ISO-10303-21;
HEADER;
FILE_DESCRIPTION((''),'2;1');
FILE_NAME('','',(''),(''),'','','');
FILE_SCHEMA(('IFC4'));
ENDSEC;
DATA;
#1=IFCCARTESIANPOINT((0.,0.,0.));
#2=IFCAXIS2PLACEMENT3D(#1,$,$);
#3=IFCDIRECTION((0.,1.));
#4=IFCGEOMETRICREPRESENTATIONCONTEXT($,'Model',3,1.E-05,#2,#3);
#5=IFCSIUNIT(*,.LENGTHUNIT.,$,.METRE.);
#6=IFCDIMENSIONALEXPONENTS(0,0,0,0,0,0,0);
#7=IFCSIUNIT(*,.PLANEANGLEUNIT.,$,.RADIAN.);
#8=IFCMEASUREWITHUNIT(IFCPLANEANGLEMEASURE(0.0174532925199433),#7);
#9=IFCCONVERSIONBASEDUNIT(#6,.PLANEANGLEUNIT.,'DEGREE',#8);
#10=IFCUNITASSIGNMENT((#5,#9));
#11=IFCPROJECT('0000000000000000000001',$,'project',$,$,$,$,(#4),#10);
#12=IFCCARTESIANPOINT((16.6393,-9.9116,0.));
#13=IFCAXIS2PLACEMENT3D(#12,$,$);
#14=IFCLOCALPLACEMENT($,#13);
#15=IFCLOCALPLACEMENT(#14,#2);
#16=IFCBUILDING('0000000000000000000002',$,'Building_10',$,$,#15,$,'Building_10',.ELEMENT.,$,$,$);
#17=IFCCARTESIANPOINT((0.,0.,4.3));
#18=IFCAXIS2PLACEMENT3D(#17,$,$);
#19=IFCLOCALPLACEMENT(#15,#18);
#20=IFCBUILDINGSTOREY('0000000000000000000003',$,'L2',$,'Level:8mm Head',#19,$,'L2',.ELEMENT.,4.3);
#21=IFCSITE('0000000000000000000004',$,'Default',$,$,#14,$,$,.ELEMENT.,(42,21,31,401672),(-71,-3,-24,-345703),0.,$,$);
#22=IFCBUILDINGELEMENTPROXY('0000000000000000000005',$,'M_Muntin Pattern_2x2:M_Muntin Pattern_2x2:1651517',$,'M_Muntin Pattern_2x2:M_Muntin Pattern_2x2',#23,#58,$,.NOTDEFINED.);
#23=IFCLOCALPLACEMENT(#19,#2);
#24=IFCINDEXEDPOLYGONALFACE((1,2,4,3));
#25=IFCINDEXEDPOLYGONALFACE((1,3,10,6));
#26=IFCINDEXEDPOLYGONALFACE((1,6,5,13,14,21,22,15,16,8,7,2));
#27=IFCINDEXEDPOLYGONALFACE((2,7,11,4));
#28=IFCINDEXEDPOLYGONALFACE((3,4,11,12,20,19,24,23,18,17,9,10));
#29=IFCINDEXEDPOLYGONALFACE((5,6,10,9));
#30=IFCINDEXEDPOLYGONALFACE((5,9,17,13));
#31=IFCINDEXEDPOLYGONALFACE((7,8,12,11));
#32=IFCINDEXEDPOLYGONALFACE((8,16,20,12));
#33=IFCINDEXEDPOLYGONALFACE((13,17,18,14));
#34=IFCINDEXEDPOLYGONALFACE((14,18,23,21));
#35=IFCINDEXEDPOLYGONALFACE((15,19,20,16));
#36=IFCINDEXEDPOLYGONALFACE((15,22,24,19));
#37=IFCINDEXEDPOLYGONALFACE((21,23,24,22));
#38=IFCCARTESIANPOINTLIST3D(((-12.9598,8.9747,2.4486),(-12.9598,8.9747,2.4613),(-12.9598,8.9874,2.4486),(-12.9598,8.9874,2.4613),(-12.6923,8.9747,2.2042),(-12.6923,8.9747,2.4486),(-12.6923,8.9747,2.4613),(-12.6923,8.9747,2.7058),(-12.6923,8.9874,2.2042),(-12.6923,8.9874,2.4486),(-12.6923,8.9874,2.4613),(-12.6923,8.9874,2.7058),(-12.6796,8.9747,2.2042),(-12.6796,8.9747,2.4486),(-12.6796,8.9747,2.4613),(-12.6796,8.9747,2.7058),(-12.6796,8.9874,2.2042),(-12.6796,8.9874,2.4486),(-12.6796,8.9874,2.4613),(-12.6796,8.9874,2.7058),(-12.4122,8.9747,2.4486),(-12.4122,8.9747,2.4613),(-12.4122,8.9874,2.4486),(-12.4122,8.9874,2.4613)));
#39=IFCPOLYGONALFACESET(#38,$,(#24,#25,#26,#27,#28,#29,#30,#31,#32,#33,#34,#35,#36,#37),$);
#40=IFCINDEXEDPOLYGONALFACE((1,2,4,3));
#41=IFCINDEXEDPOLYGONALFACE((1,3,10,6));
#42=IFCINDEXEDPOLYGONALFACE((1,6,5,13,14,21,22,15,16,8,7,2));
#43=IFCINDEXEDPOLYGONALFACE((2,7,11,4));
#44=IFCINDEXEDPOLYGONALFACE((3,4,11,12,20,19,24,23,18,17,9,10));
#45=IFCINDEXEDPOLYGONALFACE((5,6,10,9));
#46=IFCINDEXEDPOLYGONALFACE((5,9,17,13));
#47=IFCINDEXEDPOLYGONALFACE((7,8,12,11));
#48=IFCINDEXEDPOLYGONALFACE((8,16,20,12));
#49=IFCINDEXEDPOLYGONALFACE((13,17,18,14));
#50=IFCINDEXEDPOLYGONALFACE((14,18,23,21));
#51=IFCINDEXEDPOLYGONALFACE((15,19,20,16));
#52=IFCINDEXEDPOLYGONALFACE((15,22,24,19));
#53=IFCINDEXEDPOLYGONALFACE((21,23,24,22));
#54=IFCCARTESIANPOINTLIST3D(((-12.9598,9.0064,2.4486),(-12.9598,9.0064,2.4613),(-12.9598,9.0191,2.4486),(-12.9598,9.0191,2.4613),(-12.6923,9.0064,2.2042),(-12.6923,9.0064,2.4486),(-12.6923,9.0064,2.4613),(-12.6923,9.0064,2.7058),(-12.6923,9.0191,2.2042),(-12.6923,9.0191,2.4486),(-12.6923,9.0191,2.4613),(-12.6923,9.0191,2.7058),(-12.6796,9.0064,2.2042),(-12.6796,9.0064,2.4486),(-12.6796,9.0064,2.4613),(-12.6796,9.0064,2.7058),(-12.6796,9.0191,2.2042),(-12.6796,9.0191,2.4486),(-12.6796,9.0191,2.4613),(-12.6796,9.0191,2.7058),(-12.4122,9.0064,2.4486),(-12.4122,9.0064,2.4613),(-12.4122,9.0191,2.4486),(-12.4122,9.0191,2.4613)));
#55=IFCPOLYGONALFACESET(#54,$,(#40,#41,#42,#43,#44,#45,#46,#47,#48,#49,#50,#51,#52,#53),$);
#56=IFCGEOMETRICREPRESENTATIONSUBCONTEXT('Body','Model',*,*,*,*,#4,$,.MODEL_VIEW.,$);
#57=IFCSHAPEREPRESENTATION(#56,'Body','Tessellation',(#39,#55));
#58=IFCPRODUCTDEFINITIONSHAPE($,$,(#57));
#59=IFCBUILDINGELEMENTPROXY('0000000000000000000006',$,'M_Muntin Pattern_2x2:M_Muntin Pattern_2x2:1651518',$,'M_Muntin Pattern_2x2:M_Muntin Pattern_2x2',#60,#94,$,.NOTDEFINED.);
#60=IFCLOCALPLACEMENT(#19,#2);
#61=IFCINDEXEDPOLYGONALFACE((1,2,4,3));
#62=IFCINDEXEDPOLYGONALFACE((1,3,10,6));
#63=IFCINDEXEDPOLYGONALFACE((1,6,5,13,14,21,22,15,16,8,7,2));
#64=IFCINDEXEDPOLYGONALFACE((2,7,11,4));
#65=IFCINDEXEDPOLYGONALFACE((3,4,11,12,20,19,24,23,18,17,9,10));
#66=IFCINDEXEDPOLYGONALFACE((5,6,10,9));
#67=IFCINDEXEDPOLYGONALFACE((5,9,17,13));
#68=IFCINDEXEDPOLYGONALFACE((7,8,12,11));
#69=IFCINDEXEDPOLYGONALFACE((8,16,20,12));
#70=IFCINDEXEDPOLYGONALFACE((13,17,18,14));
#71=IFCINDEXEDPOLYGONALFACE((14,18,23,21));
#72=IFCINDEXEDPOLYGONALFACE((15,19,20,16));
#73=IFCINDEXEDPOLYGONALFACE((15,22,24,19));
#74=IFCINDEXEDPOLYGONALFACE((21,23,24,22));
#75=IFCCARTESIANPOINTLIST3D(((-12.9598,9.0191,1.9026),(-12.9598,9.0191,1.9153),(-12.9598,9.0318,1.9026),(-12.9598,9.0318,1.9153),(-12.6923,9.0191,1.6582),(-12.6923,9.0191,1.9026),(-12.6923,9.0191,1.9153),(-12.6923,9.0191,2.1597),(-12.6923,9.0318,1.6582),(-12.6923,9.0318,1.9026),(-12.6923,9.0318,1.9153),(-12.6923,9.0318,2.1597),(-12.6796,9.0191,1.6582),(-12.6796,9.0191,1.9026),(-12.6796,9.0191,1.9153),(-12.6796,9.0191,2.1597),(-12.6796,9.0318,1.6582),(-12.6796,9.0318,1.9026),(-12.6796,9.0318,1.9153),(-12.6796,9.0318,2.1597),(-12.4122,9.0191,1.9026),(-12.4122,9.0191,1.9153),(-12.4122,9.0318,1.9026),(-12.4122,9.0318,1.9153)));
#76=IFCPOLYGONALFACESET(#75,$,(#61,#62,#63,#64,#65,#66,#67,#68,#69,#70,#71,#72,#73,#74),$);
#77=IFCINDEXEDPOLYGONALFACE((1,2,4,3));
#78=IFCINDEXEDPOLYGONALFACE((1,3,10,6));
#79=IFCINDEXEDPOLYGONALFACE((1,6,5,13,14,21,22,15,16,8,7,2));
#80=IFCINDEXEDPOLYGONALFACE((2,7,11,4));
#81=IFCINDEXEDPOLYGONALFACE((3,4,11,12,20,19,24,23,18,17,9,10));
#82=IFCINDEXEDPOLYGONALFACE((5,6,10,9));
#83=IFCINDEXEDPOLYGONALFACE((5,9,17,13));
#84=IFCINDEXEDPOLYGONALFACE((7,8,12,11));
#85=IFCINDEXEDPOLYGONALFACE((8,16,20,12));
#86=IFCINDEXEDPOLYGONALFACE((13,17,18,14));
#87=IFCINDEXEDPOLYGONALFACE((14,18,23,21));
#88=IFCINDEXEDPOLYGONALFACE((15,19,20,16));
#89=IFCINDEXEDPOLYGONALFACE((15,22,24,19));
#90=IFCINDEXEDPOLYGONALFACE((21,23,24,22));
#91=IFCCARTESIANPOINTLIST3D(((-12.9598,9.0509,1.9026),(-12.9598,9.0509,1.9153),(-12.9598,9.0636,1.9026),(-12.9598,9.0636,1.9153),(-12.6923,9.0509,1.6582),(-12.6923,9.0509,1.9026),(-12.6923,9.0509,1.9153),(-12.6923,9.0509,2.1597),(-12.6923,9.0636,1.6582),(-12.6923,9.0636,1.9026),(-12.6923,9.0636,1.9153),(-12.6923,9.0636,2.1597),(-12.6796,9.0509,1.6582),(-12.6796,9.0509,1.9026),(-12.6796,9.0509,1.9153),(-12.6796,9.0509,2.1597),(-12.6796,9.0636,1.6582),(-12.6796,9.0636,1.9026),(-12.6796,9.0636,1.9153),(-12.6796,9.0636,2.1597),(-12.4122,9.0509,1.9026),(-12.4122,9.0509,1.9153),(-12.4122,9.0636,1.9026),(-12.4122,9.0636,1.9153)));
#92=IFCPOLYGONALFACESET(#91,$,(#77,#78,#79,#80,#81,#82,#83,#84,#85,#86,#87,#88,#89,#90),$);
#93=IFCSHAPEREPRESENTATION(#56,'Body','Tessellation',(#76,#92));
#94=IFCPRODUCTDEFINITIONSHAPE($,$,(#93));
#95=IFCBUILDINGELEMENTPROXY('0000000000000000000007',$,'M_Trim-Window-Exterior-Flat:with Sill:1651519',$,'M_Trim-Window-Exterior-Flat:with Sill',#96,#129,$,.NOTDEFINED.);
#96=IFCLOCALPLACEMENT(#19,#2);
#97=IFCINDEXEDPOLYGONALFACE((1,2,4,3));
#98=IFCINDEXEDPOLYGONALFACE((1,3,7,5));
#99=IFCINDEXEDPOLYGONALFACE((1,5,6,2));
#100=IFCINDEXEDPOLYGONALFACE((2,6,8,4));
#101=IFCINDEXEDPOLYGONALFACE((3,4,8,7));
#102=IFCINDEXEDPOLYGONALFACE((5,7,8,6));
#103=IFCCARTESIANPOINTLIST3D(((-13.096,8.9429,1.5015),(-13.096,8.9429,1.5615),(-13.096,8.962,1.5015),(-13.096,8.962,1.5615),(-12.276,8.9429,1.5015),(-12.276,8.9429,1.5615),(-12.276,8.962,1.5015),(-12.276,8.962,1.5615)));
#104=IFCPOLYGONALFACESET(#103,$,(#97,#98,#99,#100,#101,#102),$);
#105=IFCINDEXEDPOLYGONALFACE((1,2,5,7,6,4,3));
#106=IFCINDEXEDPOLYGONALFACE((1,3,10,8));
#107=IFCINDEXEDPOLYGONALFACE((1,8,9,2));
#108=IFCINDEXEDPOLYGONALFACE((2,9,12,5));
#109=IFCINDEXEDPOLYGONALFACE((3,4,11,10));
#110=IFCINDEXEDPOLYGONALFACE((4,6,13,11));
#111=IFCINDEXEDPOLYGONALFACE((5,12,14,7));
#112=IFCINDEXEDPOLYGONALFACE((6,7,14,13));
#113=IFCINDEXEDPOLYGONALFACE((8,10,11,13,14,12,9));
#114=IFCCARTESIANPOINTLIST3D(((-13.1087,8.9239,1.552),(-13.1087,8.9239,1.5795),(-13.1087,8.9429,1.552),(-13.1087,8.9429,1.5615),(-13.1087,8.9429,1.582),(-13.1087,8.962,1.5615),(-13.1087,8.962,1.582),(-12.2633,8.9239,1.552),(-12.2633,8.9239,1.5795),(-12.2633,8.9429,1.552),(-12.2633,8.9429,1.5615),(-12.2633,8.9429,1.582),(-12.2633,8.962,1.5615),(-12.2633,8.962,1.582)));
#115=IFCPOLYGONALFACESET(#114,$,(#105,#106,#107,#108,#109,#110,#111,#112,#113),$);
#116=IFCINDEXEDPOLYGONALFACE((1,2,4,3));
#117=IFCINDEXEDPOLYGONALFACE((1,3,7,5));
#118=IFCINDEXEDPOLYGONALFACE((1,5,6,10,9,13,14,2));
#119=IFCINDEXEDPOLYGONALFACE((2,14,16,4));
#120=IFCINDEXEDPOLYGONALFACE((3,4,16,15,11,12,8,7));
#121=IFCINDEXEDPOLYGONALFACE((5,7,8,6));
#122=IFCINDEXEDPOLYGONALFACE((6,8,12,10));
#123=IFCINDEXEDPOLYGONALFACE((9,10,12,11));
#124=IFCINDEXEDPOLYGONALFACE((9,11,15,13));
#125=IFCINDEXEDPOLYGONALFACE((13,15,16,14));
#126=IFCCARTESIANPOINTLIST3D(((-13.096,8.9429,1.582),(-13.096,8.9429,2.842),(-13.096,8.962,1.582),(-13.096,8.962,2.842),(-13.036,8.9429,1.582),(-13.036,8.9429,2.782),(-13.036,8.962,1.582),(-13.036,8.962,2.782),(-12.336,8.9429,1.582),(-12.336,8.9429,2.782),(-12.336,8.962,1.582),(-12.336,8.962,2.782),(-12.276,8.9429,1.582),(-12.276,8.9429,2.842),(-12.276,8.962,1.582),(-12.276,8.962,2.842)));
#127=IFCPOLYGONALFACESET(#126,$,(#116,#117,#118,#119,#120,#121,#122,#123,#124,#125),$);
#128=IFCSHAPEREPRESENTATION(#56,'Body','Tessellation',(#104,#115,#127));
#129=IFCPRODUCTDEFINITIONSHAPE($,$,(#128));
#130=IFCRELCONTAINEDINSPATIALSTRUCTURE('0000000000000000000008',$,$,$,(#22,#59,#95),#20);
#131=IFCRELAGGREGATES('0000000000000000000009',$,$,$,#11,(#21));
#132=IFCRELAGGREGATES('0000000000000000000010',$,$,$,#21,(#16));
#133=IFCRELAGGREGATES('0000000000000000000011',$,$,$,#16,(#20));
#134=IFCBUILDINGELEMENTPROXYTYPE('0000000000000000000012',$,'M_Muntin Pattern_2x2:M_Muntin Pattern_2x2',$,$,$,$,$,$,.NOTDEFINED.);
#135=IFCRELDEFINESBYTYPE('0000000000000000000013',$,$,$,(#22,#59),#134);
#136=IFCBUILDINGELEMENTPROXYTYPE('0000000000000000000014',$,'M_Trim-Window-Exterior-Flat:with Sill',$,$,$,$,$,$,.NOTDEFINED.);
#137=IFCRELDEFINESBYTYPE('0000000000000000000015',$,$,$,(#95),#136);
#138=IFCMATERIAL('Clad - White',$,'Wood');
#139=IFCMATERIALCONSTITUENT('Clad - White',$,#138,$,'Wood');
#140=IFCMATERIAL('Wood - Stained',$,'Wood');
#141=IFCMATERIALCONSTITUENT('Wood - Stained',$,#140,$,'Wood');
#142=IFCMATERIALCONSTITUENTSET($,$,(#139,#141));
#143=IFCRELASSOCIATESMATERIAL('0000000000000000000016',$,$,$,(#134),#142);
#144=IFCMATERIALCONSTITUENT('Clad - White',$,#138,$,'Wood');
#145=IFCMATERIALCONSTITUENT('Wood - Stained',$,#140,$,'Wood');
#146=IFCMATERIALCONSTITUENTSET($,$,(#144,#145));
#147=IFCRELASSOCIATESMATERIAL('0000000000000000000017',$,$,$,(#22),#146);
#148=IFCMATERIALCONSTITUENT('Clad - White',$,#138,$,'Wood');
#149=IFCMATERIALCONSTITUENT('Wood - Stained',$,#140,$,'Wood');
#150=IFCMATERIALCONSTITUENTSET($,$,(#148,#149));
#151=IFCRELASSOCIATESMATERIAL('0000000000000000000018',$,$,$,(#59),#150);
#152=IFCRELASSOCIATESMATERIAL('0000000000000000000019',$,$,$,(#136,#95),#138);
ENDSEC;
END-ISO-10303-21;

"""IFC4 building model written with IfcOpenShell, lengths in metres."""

from ifc_helpers import new_model, entity, si_unit, converted_unit, direction, frame, origin, place, context, subcontext, project, spatial, indexed_curve, outline, extrude, source, transform, mapped, material, constituent, constituent_set, type_object, type_shapes, element, save


model = new_model("IFC4")

# Units and contexts
model_context = context("Model", 3, precision=1e-05, world=origin(), true_north=direction((0.0, 1.0)))
body_context = subcontext(model_context, "Body", "Model", "MODEL_VIEW")
ifc_project = project(units=[si_unit("LENGTHUNIT", "METRE"), converted_unit("PLANEANGLEUNIT", "DEGREE", entity("IfcPlaneAngleMeasure", 0.0174532925199433), si_unit("PLANEANGLEUNIT", "RADIAN"), dimensions=[0, 0, 0, 0, 0, 0, 0])], contexts=[model_context])

# Site, building, storey
site_placement = place(None, frame((16.6393, -9.9116, 0.0)))
site = spatial("IfcSite", under=ifc_project, at=site_placement, Name="Default", CompositionType="ELEMENT", RefLatitude=(42, 21, 31, 401672), RefLongitude=(-71, -3, -24, -345703), RefElevation=0.0)
building_placement = place(site_placement, origin())
building = spatial("IfcBuilding", under=site, at=building_placement, Name="Building_10", LongName="Building_10", CompositionType="ELEMENT")
storey_placement = place(building_placement, frame((0.0, 0.0, 4.3)))
storey = spatial("IfcBuildingStorey", under=building, at=storey_placement, Name="L2", ObjectType="Level:8mm Head", LongName="L2", CompositionType="ELEMENT", Elevation=4.3)

# Building element proxies
ifc_material_1 = material(Name="Clad - White", Category="Wood")
ifc_constituent_1 = constituent(ifc_material_1, Name="Clad - White", Category="Wood")
ifc_material_2 = material(Name="Wood - Stained", Category="Wood")
ifc_constituent_2 = constituent(ifc_material_2, Name="Wood - Stained", Category="Wood")
ifc_constituent_set_1 = constituent_set(constituents=[ifc_constituent_1, ifc_constituent_2])
ifc_constituent_3 = constituent(ifc_material_1, Name="Clad - White", Category="Wood")
ifc_constituent_4 = constituent(ifc_material_2, Name="Wood - Stained", Category="Wood")
ifc_constituent_set_2 = constituent_set(constituents=[ifc_constituent_3, ifc_constituent_4])
building_element_proxy_type_1 = type_object("IfcBuildingElementProxyType", Name="M_Muntin Pattern_2x2:M_Muntin Pattern_2x2", PredefinedType="NOTDEFINED", material=ifc_constituent_set_2)
shared_shape_1 = source(origin(), body_context, "Body", "SweptSolid", [
    extrude(outline(indexed_curve([(0.0064, -0.0064), (0.2508, -0.0064), (0.2508, 0.0063), (0.0064, 0.0063), (0.0064, 0.2738), (-0.0063, 0.2738), (-0.0063, 0.0063), (-0.2508, 0.0063), (-0.2508, -0.0064), (-0.0063, -0.0064), (-0.0063, -0.2738), (0.0064, -0.2738), (0.0064, -0.0064)], self_intersect=False)), frame((0.0, 0.0095, 0.2508), z_axis=(0.0, 1.0, 0.0), x_axis=(0.0, 0.0, 1.0)), (0.0, 0.0, 1.0), 0.0127),
    extrude(outline(indexed_curve([(0.0064, -0.0064), (0.2508, -0.0064), (0.2508, 0.0063), (0.0064, 0.0063), (0.0064, 0.2738), (-0.0063, 0.2738), (-0.0063, 0.0063), (-0.2508, 0.0063), (-0.2508, -0.0064), (-0.0063, -0.0064), (-0.0063, -0.2738), (0.0064, -0.2738), (0.0064, -0.0064)], self_intersect=False)), frame((0.0, -0.0222, 0.2508), z_axis=(0.0, 1.0, 0.0), x_axis=(0.0, 0.0, 1.0)), (0.0, 0.0, 1.0), 0.0127),
])
type_shapes(building_element_proxy_type_1, [shared_shape_1])
proxy_1_placement = place(storey_placement, frame((-12.686, 8.9969, 2.2042), z_axis=(0.0, 0.0, 1.0), x_axis=(-1.0, 0.0, 0.0)))
element("IfcBuildingElementProxy", 1, at=proxy_1_placement, inside=storey, type_object=building_element_proxy_type_1, material=ifc_constituent_set_1, Name="M_Muntin Pattern_2x2:M_Muntin Pattern_2x2:1651517", ObjectType="M_Muntin Pattern_2x2:M_Muntin Pattern_2x2", PredefinedType="NOTDEFINED", context=body_context, shape_type="MappedRepresentation", body=[
    mapped(shared_shape_1, transform((0.0, 0.0, 0.0), scale=1.0)),
])
ifc_constituent_5 = constituent(ifc_material_1, Name="Clad - White", Category="Wood")
ifc_constituent_6 = constituent(ifc_material_2, Name="Wood - Stained", Category="Wood")
ifc_constituent_set_3 = constituent_set(constituents=[ifc_constituent_5, ifc_constituent_6])
proxy_2_placement = place(storey_placement, frame((-12.686, 9.0413, 1.6582), z_axis=(0.0, 0.0, 1.0), x_axis=(-1.0, 0.0, 0.0)))
element("IfcBuildingElementProxy", 2, at=proxy_2_placement, inside=storey, type_object=building_element_proxy_type_1, material=ifc_constituent_set_3, Name="M_Muntin Pattern_2x2:M_Muntin Pattern_2x2:1651518", ObjectType="M_Muntin Pattern_2x2:M_Muntin Pattern_2x2", PredefinedType="NOTDEFINED", context=body_context, shape_type="MappedRepresentation", body=[
    mapped(shared_shape_1, transform((0.0, 0.0, 0.0), scale=1.0)),
])
building_element_proxy_type_2 = type_object("IfcBuildingElementProxyType", Name="M_Trim-Window-Exterior-Flat:with Sill", PredefinedType="NOTDEFINED", material=ifc_material_1)
shared_shape_2 = source(origin(), body_context, "Body", "SweptSolid", [
    extrude(outline(indexed_curve([(-0.41, -0.03), (0.41, -0.03), (0.41, 0.03), (-0.41, 0.03), (-0.41, -0.03)], self_intersect=False)), frame((0.0, -1.2504, 0.0), z_axis=(0.0, 0.0, 1.0), x_axis=(-1.0, 0.0, 0.0)), (0.0, 0.0, 1.0), 0.0191),
    extrude(outline(indexed_curve([(-0.019, -0.0152), (0.0, -0.0152), (0.0, -0.0057), (0.019, -0.0057), (0.019, 0.0148), (0.0, 0.0148), (-0.019, 0.0123), (-0.019, -0.0152)], self_intersect=False)), frame((-0.4227, -1.2148, 0.019), z_axis=(1.0, 0.0, 0.0), x_axis=(0.0, 0.0, -1.0)), (0.0, 0.0, 1.0), 0.8454),
    extrude(outline(indexed_curve([(-0.645, -0.41), (0.615, -0.41), (0.615, -0.35), (-0.585, -0.35), (-0.585, 0.35), (0.615, 0.35), (0.615, 0.41), (-0.645, 0.41), (-0.645, -0.41)], self_intersect=False)), frame((0.0, -0.585, 0.0), z_axis=(0.0, 0.0, 1.0), x_axis=(0.0, -1.0, 0.0)), (0.0, 0.0, 1.0), 0.0191),
])
type_shapes(building_element_proxy_type_2, [shared_shape_2])
proxy_3_placement = place(storey_placement, frame((-12.686, 8.962, 2.782), z_axis=(0.0, -1.0, 0.0), x_axis=(1.0, 0.0, 0.0)))
element("IfcBuildingElementProxy", 3, at=proxy_3_placement, inside=storey, type_object=building_element_proxy_type_2, material=ifc_material_1, Name="M_Trim-Window-Exterior-Flat:with Sill:1651519", ObjectType="M_Trim-Window-Exterior-Flat:with Sill", PredefinedType="NOTDEFINED", context=body_context, shape_type="MappedRepresentation", body=[
    mapped(shared_shape_2, transform((0.0, 0.0, 0.0), scale=1.0)),
])

save(model, "model.ifc")
